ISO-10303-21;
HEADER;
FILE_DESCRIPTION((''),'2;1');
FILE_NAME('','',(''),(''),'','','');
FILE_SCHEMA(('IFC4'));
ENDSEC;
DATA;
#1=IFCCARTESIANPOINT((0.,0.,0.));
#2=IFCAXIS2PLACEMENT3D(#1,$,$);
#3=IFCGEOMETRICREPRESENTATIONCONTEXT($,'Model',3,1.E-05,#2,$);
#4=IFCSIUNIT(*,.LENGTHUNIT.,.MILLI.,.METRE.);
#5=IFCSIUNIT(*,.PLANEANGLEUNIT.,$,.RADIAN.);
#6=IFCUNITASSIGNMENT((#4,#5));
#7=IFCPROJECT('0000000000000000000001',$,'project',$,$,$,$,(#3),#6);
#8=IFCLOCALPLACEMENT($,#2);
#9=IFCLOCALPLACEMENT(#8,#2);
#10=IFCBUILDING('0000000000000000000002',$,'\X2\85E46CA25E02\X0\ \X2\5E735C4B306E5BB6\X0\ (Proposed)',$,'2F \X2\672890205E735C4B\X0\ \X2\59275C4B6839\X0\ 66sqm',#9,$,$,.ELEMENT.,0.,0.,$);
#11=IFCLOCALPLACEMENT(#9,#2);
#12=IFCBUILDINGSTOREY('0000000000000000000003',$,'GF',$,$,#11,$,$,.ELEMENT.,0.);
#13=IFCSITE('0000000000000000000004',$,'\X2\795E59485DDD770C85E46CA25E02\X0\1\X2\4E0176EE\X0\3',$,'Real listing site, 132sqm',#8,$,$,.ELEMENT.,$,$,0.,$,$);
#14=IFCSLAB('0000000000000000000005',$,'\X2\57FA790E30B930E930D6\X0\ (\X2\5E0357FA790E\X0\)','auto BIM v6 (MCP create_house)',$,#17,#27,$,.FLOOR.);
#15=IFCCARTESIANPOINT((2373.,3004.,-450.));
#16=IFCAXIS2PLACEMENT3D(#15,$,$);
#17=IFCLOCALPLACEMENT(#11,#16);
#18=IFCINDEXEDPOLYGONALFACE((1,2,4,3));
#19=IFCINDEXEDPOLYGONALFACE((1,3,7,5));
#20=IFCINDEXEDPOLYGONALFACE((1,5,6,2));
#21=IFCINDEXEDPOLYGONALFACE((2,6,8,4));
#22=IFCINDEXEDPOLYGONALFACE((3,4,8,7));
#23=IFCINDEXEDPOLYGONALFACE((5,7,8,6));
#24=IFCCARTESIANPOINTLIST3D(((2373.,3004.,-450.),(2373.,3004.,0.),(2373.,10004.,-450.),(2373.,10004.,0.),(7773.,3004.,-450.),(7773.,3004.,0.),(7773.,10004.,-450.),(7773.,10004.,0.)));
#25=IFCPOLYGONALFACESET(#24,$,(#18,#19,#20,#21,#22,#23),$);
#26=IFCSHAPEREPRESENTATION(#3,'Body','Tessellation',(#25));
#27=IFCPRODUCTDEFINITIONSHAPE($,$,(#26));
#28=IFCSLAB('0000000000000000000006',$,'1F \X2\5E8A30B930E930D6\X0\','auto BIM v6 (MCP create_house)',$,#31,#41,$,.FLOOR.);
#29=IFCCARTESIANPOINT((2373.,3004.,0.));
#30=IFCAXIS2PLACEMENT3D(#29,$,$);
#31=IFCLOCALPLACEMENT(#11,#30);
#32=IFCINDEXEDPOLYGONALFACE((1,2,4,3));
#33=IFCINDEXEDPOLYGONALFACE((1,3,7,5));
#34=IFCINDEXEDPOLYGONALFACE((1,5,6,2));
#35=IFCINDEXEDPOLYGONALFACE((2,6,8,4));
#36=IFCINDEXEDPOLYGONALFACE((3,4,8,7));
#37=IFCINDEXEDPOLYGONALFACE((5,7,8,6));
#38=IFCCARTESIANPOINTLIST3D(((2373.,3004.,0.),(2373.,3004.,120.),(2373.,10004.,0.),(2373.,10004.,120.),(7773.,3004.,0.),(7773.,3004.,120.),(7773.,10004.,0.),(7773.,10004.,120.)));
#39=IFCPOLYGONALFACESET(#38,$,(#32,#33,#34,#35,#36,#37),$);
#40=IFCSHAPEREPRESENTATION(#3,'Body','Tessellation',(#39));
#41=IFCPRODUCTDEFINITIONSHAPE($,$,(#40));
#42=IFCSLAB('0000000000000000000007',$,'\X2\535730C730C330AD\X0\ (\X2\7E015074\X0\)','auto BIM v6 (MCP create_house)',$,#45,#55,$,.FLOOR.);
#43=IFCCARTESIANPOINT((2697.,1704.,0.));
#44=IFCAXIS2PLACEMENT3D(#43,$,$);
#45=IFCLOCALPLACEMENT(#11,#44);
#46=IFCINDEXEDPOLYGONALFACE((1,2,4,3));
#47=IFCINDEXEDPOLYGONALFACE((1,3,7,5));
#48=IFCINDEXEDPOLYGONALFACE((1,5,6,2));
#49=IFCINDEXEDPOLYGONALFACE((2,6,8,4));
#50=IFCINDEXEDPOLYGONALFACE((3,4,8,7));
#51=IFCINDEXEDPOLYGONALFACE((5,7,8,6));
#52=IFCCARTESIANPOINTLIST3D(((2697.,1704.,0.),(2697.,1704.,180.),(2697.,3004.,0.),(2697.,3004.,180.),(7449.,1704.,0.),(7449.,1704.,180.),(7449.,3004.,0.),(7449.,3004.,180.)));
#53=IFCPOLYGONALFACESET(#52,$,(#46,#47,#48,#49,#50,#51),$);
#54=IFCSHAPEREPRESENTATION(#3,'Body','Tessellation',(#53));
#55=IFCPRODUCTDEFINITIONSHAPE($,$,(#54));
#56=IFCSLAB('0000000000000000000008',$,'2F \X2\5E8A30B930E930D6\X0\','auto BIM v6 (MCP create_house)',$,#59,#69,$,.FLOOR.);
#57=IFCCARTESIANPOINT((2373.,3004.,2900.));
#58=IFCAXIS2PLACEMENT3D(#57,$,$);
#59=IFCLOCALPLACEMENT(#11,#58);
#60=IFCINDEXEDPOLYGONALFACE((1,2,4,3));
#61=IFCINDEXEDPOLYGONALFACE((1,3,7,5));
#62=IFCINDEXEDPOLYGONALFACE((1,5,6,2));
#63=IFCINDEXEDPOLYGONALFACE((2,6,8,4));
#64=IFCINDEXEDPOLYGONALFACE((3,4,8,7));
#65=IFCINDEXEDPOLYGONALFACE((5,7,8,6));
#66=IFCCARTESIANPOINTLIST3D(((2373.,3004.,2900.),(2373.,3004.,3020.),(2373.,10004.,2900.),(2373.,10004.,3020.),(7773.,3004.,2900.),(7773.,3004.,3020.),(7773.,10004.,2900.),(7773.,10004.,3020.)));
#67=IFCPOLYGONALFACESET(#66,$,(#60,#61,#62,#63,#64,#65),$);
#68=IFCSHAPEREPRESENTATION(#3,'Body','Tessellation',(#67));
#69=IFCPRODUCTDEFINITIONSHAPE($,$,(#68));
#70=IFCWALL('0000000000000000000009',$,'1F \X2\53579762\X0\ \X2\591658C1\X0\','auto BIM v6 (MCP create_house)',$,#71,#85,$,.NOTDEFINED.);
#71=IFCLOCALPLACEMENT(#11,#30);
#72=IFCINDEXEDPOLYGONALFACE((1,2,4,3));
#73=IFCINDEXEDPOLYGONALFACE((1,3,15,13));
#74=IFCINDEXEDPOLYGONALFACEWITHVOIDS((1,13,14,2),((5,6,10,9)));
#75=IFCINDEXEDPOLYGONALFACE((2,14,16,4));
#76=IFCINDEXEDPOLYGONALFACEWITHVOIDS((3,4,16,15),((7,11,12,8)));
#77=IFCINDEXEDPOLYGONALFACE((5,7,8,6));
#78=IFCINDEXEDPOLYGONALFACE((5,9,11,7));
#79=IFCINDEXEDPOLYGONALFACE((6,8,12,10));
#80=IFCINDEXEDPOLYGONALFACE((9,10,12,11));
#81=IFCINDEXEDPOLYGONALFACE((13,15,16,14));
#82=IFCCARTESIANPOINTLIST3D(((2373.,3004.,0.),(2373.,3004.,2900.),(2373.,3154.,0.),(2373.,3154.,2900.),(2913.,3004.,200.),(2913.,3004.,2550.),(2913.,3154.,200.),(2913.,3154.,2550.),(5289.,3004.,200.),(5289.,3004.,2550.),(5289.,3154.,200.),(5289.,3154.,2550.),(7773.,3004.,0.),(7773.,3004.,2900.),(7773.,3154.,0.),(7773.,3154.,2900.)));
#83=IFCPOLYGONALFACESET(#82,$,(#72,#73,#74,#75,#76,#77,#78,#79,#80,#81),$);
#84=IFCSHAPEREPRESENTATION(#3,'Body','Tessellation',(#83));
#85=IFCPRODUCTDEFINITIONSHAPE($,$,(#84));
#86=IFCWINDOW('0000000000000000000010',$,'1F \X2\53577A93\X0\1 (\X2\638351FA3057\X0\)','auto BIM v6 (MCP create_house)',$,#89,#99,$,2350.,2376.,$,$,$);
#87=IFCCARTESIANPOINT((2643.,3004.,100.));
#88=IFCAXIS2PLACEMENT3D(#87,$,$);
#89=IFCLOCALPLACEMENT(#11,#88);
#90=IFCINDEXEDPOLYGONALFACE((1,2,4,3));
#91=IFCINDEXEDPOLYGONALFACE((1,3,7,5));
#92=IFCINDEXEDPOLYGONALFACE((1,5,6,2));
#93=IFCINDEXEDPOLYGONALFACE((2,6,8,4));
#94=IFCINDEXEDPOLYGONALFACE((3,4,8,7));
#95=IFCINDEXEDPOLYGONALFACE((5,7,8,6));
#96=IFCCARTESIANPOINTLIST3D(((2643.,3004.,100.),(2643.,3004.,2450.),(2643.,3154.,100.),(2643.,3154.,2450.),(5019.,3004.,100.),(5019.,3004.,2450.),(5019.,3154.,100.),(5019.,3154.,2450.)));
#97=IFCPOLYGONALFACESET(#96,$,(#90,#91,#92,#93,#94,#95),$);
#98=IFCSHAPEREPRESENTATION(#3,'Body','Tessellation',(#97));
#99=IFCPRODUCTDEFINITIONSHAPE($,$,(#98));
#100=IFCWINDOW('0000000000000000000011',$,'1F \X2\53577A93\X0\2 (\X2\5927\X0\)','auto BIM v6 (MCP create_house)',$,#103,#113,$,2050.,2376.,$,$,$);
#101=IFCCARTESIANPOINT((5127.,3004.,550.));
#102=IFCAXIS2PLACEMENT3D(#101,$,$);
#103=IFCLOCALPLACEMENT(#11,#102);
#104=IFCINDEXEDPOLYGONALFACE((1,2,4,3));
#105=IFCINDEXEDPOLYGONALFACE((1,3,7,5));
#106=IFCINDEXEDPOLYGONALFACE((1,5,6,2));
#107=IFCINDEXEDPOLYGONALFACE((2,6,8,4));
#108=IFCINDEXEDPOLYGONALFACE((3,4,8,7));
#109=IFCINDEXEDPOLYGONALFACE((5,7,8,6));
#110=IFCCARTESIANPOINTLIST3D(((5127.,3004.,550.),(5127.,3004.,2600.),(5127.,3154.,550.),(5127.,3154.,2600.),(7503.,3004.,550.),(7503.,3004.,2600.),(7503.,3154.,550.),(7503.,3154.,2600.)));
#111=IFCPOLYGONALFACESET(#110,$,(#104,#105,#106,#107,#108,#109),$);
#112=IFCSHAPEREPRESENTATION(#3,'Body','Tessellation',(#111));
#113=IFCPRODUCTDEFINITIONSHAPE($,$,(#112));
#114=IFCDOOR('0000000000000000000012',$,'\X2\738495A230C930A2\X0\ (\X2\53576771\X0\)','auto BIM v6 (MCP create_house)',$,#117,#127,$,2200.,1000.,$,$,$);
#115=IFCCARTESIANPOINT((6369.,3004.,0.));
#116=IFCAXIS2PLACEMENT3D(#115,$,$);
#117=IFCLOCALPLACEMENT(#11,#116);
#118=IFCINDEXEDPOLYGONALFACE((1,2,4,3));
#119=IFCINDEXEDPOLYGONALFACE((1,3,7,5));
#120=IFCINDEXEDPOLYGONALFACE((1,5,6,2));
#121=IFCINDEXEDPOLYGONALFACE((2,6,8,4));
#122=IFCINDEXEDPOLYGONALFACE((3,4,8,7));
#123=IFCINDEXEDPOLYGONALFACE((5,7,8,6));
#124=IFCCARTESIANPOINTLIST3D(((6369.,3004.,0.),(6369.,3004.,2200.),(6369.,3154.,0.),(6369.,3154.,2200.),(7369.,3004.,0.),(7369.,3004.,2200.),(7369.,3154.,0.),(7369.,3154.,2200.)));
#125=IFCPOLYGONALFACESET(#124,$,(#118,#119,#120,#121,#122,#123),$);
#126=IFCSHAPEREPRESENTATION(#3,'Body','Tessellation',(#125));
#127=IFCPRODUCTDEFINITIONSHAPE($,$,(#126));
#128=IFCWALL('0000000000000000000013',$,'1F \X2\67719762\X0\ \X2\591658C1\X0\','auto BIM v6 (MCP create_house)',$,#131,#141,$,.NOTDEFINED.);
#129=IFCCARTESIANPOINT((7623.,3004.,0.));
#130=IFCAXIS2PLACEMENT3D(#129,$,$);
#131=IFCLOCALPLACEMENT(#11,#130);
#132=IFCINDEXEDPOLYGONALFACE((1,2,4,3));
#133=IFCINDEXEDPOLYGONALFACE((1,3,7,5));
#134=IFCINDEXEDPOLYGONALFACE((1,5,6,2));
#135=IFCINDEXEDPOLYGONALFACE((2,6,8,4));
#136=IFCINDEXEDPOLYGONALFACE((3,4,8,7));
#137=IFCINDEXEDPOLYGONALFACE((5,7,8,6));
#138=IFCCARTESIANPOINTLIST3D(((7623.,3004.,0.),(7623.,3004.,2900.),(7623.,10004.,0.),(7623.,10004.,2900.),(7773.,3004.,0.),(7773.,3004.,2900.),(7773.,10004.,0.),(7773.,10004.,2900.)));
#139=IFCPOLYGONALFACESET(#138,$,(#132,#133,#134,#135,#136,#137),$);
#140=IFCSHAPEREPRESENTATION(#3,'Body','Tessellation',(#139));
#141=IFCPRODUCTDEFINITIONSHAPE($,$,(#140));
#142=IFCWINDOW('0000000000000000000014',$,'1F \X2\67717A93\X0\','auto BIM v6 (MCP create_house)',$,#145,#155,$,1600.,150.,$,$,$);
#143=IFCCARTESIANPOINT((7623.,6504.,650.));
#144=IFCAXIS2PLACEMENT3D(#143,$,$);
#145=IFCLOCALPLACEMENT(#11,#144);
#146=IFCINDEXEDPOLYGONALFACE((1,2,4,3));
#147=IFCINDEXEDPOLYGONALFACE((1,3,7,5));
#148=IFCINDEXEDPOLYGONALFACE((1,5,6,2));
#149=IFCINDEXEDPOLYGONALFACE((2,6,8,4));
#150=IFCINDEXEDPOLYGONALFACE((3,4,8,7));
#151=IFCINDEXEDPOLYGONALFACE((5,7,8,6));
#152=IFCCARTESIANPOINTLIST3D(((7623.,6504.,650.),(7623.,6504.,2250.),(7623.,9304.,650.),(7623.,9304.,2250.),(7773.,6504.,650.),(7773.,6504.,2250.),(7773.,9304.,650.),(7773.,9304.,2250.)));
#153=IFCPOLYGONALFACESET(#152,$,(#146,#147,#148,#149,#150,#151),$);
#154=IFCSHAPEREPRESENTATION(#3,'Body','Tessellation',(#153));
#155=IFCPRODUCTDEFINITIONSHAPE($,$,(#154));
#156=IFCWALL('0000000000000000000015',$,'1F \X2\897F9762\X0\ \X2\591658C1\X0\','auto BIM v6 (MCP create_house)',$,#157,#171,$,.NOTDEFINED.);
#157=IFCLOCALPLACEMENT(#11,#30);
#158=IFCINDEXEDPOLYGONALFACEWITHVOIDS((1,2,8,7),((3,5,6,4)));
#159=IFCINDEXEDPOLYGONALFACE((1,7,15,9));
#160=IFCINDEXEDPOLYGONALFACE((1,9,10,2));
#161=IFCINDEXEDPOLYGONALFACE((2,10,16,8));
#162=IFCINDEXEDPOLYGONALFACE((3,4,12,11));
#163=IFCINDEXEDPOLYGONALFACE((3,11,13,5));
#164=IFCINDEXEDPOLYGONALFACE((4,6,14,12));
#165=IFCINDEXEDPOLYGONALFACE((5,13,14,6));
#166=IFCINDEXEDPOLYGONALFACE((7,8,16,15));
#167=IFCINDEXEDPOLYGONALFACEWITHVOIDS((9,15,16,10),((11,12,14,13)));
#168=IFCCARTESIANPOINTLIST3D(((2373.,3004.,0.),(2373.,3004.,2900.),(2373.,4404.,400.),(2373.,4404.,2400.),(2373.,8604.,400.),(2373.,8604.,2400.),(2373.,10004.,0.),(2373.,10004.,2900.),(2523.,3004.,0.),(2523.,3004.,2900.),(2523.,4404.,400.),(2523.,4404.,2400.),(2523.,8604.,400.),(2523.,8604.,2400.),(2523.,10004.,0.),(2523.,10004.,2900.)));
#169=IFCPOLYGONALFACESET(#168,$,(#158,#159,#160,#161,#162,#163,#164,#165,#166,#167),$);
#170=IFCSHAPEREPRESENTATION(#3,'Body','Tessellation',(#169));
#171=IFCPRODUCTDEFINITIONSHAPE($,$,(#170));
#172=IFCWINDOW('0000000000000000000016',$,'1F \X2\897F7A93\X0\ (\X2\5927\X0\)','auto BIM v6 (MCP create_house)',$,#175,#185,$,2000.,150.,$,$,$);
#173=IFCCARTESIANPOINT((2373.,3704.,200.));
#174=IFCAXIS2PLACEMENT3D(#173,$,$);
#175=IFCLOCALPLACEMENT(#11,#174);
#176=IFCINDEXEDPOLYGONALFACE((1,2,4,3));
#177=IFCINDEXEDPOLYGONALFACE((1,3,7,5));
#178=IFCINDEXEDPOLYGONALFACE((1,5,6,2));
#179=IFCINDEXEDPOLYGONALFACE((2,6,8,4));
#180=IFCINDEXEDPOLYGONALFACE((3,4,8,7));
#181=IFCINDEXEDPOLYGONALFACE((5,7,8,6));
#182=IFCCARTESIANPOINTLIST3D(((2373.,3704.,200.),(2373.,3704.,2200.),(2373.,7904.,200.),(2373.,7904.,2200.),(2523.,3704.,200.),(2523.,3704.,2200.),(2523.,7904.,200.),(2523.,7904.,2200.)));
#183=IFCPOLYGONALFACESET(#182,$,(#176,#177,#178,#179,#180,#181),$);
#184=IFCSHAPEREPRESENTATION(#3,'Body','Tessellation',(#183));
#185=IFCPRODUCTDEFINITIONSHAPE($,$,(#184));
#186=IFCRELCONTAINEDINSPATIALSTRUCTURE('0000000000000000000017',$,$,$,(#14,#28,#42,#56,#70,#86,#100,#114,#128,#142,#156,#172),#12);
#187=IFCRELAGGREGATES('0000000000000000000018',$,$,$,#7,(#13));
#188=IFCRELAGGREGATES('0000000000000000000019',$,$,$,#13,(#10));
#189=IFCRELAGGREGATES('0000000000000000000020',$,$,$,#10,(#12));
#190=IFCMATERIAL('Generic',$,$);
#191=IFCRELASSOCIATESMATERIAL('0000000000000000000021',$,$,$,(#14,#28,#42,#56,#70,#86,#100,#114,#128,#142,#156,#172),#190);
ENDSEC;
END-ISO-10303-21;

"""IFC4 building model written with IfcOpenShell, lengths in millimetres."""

from ifc_helpers import new_model, si_unit, frame, frame_2d, origin, place, context, project, spatial, rectangle, extrude, material, element, fill, save


model = new_model("IFC4")

# Units and contexts
model_context = context("Model", 3, precision=1e-05, world=origin())
ifc_project = project(units=[si_unit("LENGTHUNIT", "METRE", prefix="MILLI"), si_unit("PLANEANGLEUNIT", "RADIAN")], contexts=[model_context])

# Site, building, storey
site_placement = place(None, origin())
site = spatial("IfcSite", under=ifc_project, at=site_placement, Name="神奈川県藤沢市1丁目3", ObjectType="Real listing site, 132sqm", CompositionType="ELEMENT", RefElevation=0.0)
building_placement = place(site_placement, origin())
building = spatial("IfcBuilding", under=site, at=building_placement, Name="藤沢市 平屋の家 (Proposed)", ObjectType="2F 木造平屋 大屋根 66sqm", CompositionType="ELEMENT", ElevationOfRefHeight=0.0, ElevationOfTerrain=0.0)
storey_placement = place(building_placement, origin())
storey = spatial("IfcBuildingStorey", under=building, at=storey_placement, Name="GF", CompositionType="ELEMENT", Elevation=0.0)

# Slabs
ifc_material = material(Name="Generic")
slab_1_placement = place(storey_placement, frame((2373.0, 3004.0, -450.0)))
element("IfcSlab", 1, at=slab_1_placement, inside=storey, material=ifc_material, Name="基礎スラブ (布基礎)", Description="auto BIM v6 (MCP create_house)", PredefinedType="FLOOR", context=model_context, shape_type="SweptSolid", body=[
    extrude(rectangle(XDim=5400.0, YDim=7000.0, at=frame_2d((2700.0, 3500.0))), frame((2373.0, 3004.0, -450.0)), (0.0, 0.0, 1.0), 450.0),
])
slab_2_placement = place(storey_placement, frame((2373.0, 3004.0, 0.0)))
element("IfcSlab", 2, at=slab_2_placement, inside=storey, material=ifc_material, Name="1F 床スラブ", Description="auto BIM v6 (MCP create_house)", PredefinedType="FLOOR", context=model_context, shape_type="SweptSolid", body=[
    extrude(rectangle(XDim=5400.0, YDim=7000.0, at=frame_2d((2700.0, 3500.0))), frame((2373.0, 3004.0, 0.0)), (0.0, 0.0, 1.0), 120.0),
])
slab_3_placement = place(storey_placement, frame((2697.0, 1704.0, 0.0)))
element("IfcSlab", 3, at=slab_3_placement, inside=storey, material=ifc_material, Name="南デッキ (縁側)", Description="auto BIM v6 (MCP create_house)", PredefinedType="FLOOR", context=model_context, shape_type="SweptSolid", body=[
    extrude(rectangle(XDim=4752.0, YDim=1300.0, at=frame_2d((2376.0, 650.0))), frame((2697.0, 1704.0, 0.0)), (0.0, 0.0, 1.0), 180.0),
])
slab_4_placement = place(storey_placement, frame((2373.0, 3004.0, 2900.0)))
element("IfcSlab", 4, at=slab_4_placement, inside=storey, material=ifc_material, Name="2F 床スラブ", Description="auto BIM v6 (MCP create_house)", PredefinedType="FLOOR", context=model_context, shape_type="SweptSolid", body=[
    extrude(rectangle(XDim=5400.0, YDim=7000.0, at=frame_2d((2700.0, 3500.0))), frame((2373.0, 3004.0, 2900.0)), (0.0, 0.0, 1.0), 120.0),
])

# Wall, openings, windows, door
wall_1_placement = place(storey_placement, frame((2373.0, 3004.0, 0.0)))
wall_1 = element("IfcWall", 5, at=wall_1_placement, inside=storey, material=ifc_material, Name="1F 南面 外壁", Description="auto BIM v6 (MCP create_house)", PredefinedType="NOTDEFINED", context=model_context, shape_type="SweptSolid", body=[
    extrude(rectangle(XDim=5400.0, YDim=150.0, at=frame_2d((2700.0, 75.0))), frame((2373.0, 3004.0, 0.0)), (0.0, 0.0, 1.0), 2900.0),
])
opening_1_placement = place(storey_placement, frame((2643.0, 3004.0, 100.0)))
opening_1 = element("IfcOpeningElement", 6, at=opening_1_placement, cuts=wall_1, PredefinedType="NOTDEFINED", context=model_context, shape_type="SweptSolid", body=[
    extrude(rectangle(XDim=2376.0, YDim=150.0, at=frame_2d((1188.0, 75.0))), frame((2643.0, 3004.0, 100.0)), (0.0, 0.0, 1.0), 2350.0),
])
opening_2_placement = place(storey_placement, frame((5127.0, 3004.0, 550.0)))
opening_2 = element("IfcOpeningElement", 7, at=opening_2_placement, cuts=wall_1, PredefinedType="NOTDEFINED", context=model_context, shape_type="SweptSolid", body=[
    extrude(rectangle(XDim=2376.0, YDim=150.0, at=frame_2d((1188.0, 75.0))), frame((5127.0, 3004.0, 550.0)), (0.0, 0.0, 1.0), 2050.0),
])
opening_3_placement = place(storey_placement, frame((6369.0, 3004.0, 0.0)))
opening_3 = element("IfcOpeningElement", 8, at=opening_3_placement, cuts=wall_1, PredefinedType="NOTDEFINED", context=model_context, shape_type="SweptSolid", body=[
    extrude(rectangle(XDim=1000.0, YDim=150.0, at=frame_2d((500.0, 75.0))), frame((6369.0, 3004.0, 0.0)), (0.0, 0.0, 1.0), 2200.0),
])
window_1_placement = place(storey_placement, frame((2643.0, 3004.0, 100.0)))
window_1 = element("IfcWindow", 9, at=window_1_placement, inside=storey, material=ifc_material, Name="1F 南窓1 (掃出し)", Description="auto BIM v6 (MCP create_house)", OverallHeight=2350.0, OverallWidth=2376.0, context=model_context, shape_type="SweptSolid", body=[
    extrude(rectangle(XDim=2376.0, YDim=150.0, at=frame_2d((1188.0, 75.0))), frame((2643.0, 3004.0, 100.0)), (0.0, 0.0, 1.0), 2350.0),
])
fill(opening_1, window_1)
window_2_placement = place(storey_placement, frame((5127.0, 3004.0, 550.0)))
window_2 = element("IfcWindow", 10, at=window_2_placement, inside=storey, material=ifc_material, Name="1F 南窓2 (大)", Description="auto BIM v6 (MCP create_house)", OverallHeight=2050.0, OverallWidth=2376.0, context=model_context, shape_type="SweptSolid", body=[
    extrude(rectangle(XDim=2376.0, YDim=150.0, at=frame_2d((1188.0, 75.0))), frame((5127.0, 3004.0, 550.0)), (0.0, 0.0, 1.0), 2050.0),
])
fill(opening_2, window_2)
door_placement = place(storey_placement, frame((6369.0, 3004.0, 0.0)))
door = element("IfcDoor", 11, at=door_placement, inside=storey, material=ifc_material, Name="玄関ドア (南東)", Description="auto BIM v6 (MCP create_house)", OverallHeight=2200.0, OverallWidth=1000.0, context=model_context, shape_type="SweptSolid", body=[
    extrude(rectangle(XDim=1000.0, YDim=150.0, at=frame_2d((500.0, 75.0))), frame((6369.0, 3004.0, 0.0)), (0.0, 0.0, 1.0), 2200.0),
])
fill(opening_3, door)

# Walls, openings, windows
wall_2_placement = place(storey_placement, frame((7623.0, 3004.0, 0.0)))
wall_2 = element("IfcWall", 12, at=wall_2_placement, inside=storey, material=ifc_material, Name="1F 東面 外壁", Description="auto BIM v6 (MCP create_house)", PredefinedType="NOTDEFINED", context=model_context, shape_type="SweptSolid", body=[
    extrude(rectangle(XDim=150.0, YDim=7000.0, at=frame_2d((75.0, 3500.0))), frame((7623.0, 3004.0, 0.0)), (0.0, 0.0, 1.0), 2900.0),
])
opening_4_placement = place(storey_placement, frame((7623.0, 6504.0, 650.0)))
opening_4 = element("IfcOpeningElement", 13, at=opening_4_placement, cuts=wall_2, PredefinedType="NOTDEFINED", context=model_context, shape_type="SweptSolid", body=[
    extrude(rectangle(XDim=150.0, YDim=2800.0, at=frame_2d((75.0, 1400.0))), frame((7623.0, 6504.0, 650.0)), (0.0, 0.0, 1.0), 1600.0),
])
window_3_placement = place(storey_placement, frame((7623.0, 6504.0, 650.0)))
window_3 = element("IfcWindow", 14, at=window_3_placement, inside=storey, material=ifc_material, Name="1F 東窓", Description="auto BIM v6 (MCP create_house)", OverallHeight=1600.0, OverallWidth=150.0, context=model_context, shape_type="SweptSolid", body=[
    extrude(rectangle(XDim=150.0, YDim=2800.0, at=frame_2d((75.0, 1400.0))), frame((7623.0, 6504.0, 650.0)), (0.0, 0.0, 1.0), 1600.0),
])
fill(opening_4, window_3)
wall_3_placement = place(storey_placement, frame((2373.0, 3004.0, 0.0)))
wall_3 = element("IfcWall", 15, at=wall_3_placement, inside=storey, material=ifc_material, Name="1F 西面 外壁", Description="auto BIM v6 (MCP create_house)", PredefinedType="NOTDEFINED", context=model_context, shape_type="SweptSolid", body=[
    extrude(rectangle(XDim=150.0, YDim=7000.0, at=frame_2d((75.0, 3500.0))), frame((2373.0, 3004.0, 0.0)), (0.0, 0.0, 1.0), 2900.0),
])
opening_5_placement = place(storey_placement, frame((2373.0, 3704.0, 200.0)))
opening_5 = element("IfcOpeningElement", 16, at=opening_5_placement, cuts=wall_3, PredefinedType="NOTDEFINED", context=model_context, shape_type="SweptSolid", body=[
    extrude(rectangle(XDim=150.0, YDim=4200.0, at=frame_2d((75.0, 2100.0))), frame((2373.0, 3704.0, 200.0)), (0.0, 0.0, 1.0), 2000.0),
])
window_4_placement = place(storey_placement, frame((2373.0, 3704.0, 200.0)))
window_4 = element("IfcWindow", 17, at=window_4_placement, inside=storey, material=ifc_material, Name="1F 西窓 (大)", Description="auto BIM v6 (MCP create_house)", OverallHeight=2000.0, OverallWidth=150.0, context=model_context, shape_type="SweptSolid", body=[
    extrude(rectangle(XDim=150.0, YDim=4200.0, at=frame_2d((75.0, 2100.0))), frame((2373.0, 3704.0, 200.0)), (0.0, 0.0, 1.0), 2000.0),
])
fill(opening_5, window_4)

save(model, "model.ifc")
